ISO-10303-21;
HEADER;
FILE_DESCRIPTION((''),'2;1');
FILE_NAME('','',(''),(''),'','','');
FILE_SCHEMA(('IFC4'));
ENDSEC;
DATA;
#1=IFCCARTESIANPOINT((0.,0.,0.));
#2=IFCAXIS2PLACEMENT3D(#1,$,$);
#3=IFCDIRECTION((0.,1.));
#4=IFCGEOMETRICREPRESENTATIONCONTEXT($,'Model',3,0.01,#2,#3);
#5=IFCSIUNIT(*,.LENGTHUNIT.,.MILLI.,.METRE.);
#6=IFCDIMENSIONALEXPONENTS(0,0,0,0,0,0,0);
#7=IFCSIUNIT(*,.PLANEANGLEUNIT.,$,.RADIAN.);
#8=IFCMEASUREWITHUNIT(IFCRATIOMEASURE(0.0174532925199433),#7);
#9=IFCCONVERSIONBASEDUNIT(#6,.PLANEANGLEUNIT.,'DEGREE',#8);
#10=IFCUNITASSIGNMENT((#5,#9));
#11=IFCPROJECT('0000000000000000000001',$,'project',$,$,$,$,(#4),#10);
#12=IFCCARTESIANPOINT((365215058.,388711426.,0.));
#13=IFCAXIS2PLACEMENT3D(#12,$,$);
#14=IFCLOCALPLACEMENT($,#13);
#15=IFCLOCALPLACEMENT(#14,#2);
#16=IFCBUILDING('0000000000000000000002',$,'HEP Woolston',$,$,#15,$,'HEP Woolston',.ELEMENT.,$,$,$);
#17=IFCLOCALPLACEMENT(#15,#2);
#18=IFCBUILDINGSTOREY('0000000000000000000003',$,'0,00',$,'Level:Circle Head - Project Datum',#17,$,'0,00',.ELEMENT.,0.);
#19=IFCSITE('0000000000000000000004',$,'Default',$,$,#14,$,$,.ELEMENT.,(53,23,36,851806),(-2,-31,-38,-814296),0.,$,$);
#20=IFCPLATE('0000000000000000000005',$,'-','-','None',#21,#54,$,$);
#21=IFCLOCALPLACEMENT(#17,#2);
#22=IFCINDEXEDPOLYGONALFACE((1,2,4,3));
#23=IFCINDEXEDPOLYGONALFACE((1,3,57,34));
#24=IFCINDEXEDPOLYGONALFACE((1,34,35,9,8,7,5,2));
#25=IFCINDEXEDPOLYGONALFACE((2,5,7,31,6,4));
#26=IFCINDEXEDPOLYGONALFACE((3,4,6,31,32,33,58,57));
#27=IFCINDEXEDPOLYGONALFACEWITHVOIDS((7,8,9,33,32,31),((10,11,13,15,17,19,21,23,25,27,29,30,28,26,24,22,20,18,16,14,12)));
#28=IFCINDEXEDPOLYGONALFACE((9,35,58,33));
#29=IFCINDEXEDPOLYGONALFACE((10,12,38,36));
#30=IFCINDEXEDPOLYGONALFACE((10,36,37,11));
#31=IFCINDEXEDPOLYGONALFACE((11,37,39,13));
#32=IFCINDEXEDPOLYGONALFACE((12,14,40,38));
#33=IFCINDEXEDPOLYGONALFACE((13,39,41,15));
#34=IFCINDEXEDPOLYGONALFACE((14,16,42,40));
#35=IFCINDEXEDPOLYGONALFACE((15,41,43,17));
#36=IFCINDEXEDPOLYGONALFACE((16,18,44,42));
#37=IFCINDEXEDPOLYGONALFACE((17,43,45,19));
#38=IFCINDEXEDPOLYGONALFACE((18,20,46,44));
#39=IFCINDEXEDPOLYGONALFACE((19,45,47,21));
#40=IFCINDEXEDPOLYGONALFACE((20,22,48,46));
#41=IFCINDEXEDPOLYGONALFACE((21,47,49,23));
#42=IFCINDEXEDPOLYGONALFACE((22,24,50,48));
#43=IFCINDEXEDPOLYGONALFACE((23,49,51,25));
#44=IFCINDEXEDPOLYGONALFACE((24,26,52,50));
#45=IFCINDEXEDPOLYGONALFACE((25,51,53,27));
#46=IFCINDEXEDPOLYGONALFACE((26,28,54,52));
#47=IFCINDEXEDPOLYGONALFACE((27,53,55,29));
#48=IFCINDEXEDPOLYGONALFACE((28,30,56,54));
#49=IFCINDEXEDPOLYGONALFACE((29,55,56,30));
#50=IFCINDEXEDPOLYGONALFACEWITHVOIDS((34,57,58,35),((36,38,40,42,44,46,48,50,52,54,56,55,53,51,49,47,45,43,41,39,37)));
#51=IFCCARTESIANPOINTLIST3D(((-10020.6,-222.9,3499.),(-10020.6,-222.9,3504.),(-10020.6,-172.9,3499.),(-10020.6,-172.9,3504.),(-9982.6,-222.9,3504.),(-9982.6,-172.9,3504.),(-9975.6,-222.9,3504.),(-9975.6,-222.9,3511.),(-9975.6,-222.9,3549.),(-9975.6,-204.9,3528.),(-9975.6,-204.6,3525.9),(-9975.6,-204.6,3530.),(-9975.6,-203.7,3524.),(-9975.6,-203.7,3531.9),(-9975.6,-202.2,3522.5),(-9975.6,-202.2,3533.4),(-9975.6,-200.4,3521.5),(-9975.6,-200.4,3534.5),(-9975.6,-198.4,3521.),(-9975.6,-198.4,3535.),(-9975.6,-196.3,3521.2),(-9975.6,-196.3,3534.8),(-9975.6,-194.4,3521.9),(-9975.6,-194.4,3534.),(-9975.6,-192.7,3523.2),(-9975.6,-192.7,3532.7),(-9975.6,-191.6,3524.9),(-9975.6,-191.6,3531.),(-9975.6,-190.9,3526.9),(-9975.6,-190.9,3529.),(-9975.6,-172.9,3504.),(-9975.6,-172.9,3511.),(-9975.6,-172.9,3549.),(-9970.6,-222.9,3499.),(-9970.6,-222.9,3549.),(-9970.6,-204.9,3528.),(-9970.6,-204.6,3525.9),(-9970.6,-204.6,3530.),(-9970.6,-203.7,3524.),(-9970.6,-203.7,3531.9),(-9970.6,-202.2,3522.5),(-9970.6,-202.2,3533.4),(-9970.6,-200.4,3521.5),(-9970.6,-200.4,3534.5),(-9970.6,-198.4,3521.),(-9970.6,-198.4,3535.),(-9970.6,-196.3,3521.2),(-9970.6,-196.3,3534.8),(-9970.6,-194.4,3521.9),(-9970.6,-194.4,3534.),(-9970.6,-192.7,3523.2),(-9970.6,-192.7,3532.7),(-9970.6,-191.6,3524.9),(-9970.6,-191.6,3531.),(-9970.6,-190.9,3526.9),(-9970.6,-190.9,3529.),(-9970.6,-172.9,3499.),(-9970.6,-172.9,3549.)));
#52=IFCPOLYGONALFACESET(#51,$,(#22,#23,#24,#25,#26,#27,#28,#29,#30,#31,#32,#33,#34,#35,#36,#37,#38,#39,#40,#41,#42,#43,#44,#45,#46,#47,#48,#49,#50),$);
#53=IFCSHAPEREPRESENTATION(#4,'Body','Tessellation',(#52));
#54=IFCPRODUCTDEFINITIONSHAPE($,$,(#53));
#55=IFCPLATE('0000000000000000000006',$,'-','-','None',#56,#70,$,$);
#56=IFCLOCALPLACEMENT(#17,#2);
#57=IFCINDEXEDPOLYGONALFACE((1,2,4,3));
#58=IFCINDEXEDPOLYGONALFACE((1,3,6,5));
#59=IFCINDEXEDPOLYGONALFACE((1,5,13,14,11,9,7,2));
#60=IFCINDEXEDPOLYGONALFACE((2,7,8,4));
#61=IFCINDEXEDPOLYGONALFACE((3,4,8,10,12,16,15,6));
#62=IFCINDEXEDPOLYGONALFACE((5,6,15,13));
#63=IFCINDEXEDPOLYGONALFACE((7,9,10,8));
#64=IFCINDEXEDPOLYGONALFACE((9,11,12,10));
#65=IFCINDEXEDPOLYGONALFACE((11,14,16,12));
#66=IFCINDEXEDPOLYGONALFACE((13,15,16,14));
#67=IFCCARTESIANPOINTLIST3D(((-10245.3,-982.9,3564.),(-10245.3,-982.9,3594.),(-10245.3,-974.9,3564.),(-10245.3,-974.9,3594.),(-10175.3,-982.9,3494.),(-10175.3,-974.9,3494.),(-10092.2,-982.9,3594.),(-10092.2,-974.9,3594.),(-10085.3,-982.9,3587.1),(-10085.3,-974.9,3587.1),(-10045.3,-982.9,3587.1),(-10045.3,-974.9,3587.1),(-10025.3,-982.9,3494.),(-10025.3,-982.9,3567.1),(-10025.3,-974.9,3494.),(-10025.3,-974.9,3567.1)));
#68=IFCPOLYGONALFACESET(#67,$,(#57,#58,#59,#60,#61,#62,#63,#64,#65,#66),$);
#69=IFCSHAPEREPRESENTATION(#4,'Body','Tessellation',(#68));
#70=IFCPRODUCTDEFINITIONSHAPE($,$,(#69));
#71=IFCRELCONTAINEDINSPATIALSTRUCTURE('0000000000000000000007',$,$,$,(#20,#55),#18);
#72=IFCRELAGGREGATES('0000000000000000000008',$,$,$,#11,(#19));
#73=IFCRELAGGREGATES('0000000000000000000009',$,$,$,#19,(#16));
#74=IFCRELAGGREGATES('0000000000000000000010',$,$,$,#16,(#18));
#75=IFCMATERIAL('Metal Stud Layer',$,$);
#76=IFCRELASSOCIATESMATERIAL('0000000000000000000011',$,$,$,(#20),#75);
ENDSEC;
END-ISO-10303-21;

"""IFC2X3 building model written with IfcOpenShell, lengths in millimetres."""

from ifc_helpers import new_model, entity, si_unit, converted_unit, point, direction, frame, frame_2d, origin, origin_with_axes, origin_2d_with_axis, place, context, project, spatial, polyline, circle_curve, line_curve, trimmed, segment, composite_curve, circle, outline, extrude, material, element, save


model = new_model("IFC2X3")

# Units and contexts
model_context = context("Model", 3, precision=0.01, world=origin(), true_north=direction((0.0, 1.0)))
ifc_project = project(units=[si_unit("LENGTHUNIT", "METRE", prefix="MILLI"), converted_unit("PLANEANGLEUNIT", "DEGREE", entity("IfcRatioMeasure", 0.0174532925199433), si_unit("PLANEANGLEUNIT", "RADIAN"), dimensions=[0, 0, 0, 0, 0, 0, 0])], contexts=[model_context])

# Site, building, storey
site_placement = place(None, frame((365215058.0, 388711426.0, 0.0)))
site = spatial("IfcSite", under=ifc_project, at=site_placement, Name="Default", CompositionType="ELEMENT", RefLatitude=(53, 23, 36, 851806), RefLongitude=(-2, -31, -38, -814296), RefElevation=0.0)
building_placement = place(site_placement, origin())
building = spatial("IfcBuilding", under=site, at=building_placement, Name="HEP Woolston", LongName="HEP Woolston", CompositionType="ELEMENT")
storey_placement = place(building_placement, origin())
storey = spatial("IfcBuildingStorey", under=building, at=storey_placement, Name="0,00", ObjectType="Level:Circle Head - Project Datum", LongName="0,00", CompositionType="ELEMENT", Elevation=0.0)

# Plate, openings
ifc_material_1 = material(Name="Metal Stud Layer")
plate_1_placement = place(storey_placement, frame((-9970.6, -222.9, 3499.0), z_axis=(0.0, 1.0, 0.0), x_axis=(-1.0, 0.0, 0.0)))
plate_1 = element("IfcPlate", 1, at=plate_1_placement, inside=storey, material=ifc_material_1, Name="-", Description="-", ObjectType="None", context=model_context, shape_type="SweptSolid", body=[
    extrude(outline(polyline([(0.0, 0.0), (50.0, 0.0), (50.0, 5.0), (5.0, 5.0), (5.0, 50.0), (0.0, 50.0), (0.0, 0.0)])), origin_with_axes(), (0.0, 0.0, 1.0), 50.0),
])
opening_1_placement = place(plate_1_placement, frame((0.0, 0.0, 0.0), z_axis=(0.0, 0.0, 1.0), x_axis=(1.0, 0.0, 0.0)))
element("IfcOpeningElement", 2, at=opening_1_placement, cuts=plate_1, ObjectType="Opening", context=model_context, shape_type="SweptSolid", body=[
    extrude(outline(composite_curve([segment(trimmed(line_curve((50.0, 5.0), (1.0, 0.0), 3.532613), [point((50.0, 5.0))], [point((46.5, 5.0))], True, "CARTESIAN"), True, "CONTINUOUS"), segment(trimmed(circle_curve(frame_2d((46.5, 1.5), x_axis=(-1.0, 0.0)), 3.5), [point((46.5, 5.0))], [point((50.0, 1.5))], False, "CARTESIAN"), True, "CONTINUOUS"), segment(trimmed(line_curve((50.0, 1.5), (0.0, -1.0), 3.532613), [point((50.0, 1.5))], [point((50.0, 5.0))], True, "CARTESIAN"), True, "CONTINUOUS")], self_intersect="UNKNOWN")), origin(), (0.0, 0.0, 1.0), 50.0),
])
opening_2_placement = place(plate_1_placement, origin_with_axes())
element("IfcOpeningElement", 3, at=opening_2_placement, cuts=plate_1, ObjectType="Opening", context=model_context, shape_type="SweptSolid", body=[
    extrude(outline(composite_curve([segment(trimmed(line_curve((5.0, 5.0), (0.0, -1.0), 7.046301), [point((5.0, 5.0))], [point((5.0, 12.0))], False, "CARTESIAN"), True, "CONTINUOUS"), segment(trimmed(circle_curve(frame_2d((12.0, 12.0), x_axis=(1.0, 0.0)), 7.0), [point((5.0, 12.0))], [point((12.0, 5.0))], True, "CARTESIAN"), True, "CONTINUOUS"), segment(trimmed(line_curve((12.0, 5.0), (1.0, 0.0), 7.046301), [point((12.0, 5.0))], [point((5.0, 5.0))], False, "CARTESIAN"), True, "CONTINUOUS")], self_intersect="UNKNOWN")), origin(), (0.0, 0.0, 1.0), 50.0),
])
opening_3_placement = place(plate_1_placement, frame((0.0, 0.0, 0.0), z_axis=(0.0, 0.0, 1.0), x_axis=(1.0, 0.0, 0.0)))
element("IfcOpeningElement", 4, at=opening_3_placement, cuts=plate_1, ObjectType="Opening", context=model_context, shape_type="SweptSolid", body=[
    extrude(outline(composite_curve([segment(trimmed(line_curve((5.0, 50.0), (1.0, 0.0), 3.4874), [point((5.0, 50.0))], [point((1.5, 50.0))], True, "CARTESIAN"), True, "CONTINUOUS"), segment(trimmed(circle_curve(frame_2d((1.5, 46.5), x_axis=(-1.0, 0.0)), 3.5), [point((1.5, 50.0))], [point((5.0, 46.5))], False, "CARTESIAN"), True, "CONTINUOUS"), segment(trimmed(line_curve((5.0, 46.5), (0.0, -1.0), 3.4874), [point((5.0, 46.5))], [point((5.0, 50.0))], True, "CARTESIAN"), True, "CONTINUOUS")], self_intersect="UNKNOWN")), origin(), (0.0, 0.0, 1.0), 50.0),
])
opening_4_placement = place(plate_1_placement, frame((-0.5, 29.0, 25.0), z_axis=(1.0, 0.0, 0.0), x_axis=(0.0, 0.0, -1.0)))
element("IfcOpeningElement", 5, at=opening_4_placement, cuts=plate_1, ObjectType="Opening", context=model_context, shape_type="SweptSolid", body=[
    extrude(circle(Radius=7.0, at=origin_2d_with_axis()), origin(), (0.0, 0.0, 1.0), 6.0),
])

# Plate
plate_2_placement = place(storey_placement, frame((-10025.3, -982.9, 3567.1), z_axis=(0.0, 1.0, 0.0), x_axis=(-1.0, 0.0, 0.0)))
element("IfcPlate", 6, at=plate_2_placement, inside=storey, Name="-", Description="-", ObjectType="None", context=model_context, shape_type="SweptSolid", body=[
    extrude(outline(polyline([(0.0, 0.0), (0.0, -73.1), (150.0, -73.1), (220.0, -3.1), (220.0, 26.9), (66.9, 26.9), (60.0, 20.0), (20.0, 20.0), (0.0, 0.0)])), origin_with_axes(), (0.0, 0.0, 1.0), 8.0),
])

save(model, "model.ifc")
